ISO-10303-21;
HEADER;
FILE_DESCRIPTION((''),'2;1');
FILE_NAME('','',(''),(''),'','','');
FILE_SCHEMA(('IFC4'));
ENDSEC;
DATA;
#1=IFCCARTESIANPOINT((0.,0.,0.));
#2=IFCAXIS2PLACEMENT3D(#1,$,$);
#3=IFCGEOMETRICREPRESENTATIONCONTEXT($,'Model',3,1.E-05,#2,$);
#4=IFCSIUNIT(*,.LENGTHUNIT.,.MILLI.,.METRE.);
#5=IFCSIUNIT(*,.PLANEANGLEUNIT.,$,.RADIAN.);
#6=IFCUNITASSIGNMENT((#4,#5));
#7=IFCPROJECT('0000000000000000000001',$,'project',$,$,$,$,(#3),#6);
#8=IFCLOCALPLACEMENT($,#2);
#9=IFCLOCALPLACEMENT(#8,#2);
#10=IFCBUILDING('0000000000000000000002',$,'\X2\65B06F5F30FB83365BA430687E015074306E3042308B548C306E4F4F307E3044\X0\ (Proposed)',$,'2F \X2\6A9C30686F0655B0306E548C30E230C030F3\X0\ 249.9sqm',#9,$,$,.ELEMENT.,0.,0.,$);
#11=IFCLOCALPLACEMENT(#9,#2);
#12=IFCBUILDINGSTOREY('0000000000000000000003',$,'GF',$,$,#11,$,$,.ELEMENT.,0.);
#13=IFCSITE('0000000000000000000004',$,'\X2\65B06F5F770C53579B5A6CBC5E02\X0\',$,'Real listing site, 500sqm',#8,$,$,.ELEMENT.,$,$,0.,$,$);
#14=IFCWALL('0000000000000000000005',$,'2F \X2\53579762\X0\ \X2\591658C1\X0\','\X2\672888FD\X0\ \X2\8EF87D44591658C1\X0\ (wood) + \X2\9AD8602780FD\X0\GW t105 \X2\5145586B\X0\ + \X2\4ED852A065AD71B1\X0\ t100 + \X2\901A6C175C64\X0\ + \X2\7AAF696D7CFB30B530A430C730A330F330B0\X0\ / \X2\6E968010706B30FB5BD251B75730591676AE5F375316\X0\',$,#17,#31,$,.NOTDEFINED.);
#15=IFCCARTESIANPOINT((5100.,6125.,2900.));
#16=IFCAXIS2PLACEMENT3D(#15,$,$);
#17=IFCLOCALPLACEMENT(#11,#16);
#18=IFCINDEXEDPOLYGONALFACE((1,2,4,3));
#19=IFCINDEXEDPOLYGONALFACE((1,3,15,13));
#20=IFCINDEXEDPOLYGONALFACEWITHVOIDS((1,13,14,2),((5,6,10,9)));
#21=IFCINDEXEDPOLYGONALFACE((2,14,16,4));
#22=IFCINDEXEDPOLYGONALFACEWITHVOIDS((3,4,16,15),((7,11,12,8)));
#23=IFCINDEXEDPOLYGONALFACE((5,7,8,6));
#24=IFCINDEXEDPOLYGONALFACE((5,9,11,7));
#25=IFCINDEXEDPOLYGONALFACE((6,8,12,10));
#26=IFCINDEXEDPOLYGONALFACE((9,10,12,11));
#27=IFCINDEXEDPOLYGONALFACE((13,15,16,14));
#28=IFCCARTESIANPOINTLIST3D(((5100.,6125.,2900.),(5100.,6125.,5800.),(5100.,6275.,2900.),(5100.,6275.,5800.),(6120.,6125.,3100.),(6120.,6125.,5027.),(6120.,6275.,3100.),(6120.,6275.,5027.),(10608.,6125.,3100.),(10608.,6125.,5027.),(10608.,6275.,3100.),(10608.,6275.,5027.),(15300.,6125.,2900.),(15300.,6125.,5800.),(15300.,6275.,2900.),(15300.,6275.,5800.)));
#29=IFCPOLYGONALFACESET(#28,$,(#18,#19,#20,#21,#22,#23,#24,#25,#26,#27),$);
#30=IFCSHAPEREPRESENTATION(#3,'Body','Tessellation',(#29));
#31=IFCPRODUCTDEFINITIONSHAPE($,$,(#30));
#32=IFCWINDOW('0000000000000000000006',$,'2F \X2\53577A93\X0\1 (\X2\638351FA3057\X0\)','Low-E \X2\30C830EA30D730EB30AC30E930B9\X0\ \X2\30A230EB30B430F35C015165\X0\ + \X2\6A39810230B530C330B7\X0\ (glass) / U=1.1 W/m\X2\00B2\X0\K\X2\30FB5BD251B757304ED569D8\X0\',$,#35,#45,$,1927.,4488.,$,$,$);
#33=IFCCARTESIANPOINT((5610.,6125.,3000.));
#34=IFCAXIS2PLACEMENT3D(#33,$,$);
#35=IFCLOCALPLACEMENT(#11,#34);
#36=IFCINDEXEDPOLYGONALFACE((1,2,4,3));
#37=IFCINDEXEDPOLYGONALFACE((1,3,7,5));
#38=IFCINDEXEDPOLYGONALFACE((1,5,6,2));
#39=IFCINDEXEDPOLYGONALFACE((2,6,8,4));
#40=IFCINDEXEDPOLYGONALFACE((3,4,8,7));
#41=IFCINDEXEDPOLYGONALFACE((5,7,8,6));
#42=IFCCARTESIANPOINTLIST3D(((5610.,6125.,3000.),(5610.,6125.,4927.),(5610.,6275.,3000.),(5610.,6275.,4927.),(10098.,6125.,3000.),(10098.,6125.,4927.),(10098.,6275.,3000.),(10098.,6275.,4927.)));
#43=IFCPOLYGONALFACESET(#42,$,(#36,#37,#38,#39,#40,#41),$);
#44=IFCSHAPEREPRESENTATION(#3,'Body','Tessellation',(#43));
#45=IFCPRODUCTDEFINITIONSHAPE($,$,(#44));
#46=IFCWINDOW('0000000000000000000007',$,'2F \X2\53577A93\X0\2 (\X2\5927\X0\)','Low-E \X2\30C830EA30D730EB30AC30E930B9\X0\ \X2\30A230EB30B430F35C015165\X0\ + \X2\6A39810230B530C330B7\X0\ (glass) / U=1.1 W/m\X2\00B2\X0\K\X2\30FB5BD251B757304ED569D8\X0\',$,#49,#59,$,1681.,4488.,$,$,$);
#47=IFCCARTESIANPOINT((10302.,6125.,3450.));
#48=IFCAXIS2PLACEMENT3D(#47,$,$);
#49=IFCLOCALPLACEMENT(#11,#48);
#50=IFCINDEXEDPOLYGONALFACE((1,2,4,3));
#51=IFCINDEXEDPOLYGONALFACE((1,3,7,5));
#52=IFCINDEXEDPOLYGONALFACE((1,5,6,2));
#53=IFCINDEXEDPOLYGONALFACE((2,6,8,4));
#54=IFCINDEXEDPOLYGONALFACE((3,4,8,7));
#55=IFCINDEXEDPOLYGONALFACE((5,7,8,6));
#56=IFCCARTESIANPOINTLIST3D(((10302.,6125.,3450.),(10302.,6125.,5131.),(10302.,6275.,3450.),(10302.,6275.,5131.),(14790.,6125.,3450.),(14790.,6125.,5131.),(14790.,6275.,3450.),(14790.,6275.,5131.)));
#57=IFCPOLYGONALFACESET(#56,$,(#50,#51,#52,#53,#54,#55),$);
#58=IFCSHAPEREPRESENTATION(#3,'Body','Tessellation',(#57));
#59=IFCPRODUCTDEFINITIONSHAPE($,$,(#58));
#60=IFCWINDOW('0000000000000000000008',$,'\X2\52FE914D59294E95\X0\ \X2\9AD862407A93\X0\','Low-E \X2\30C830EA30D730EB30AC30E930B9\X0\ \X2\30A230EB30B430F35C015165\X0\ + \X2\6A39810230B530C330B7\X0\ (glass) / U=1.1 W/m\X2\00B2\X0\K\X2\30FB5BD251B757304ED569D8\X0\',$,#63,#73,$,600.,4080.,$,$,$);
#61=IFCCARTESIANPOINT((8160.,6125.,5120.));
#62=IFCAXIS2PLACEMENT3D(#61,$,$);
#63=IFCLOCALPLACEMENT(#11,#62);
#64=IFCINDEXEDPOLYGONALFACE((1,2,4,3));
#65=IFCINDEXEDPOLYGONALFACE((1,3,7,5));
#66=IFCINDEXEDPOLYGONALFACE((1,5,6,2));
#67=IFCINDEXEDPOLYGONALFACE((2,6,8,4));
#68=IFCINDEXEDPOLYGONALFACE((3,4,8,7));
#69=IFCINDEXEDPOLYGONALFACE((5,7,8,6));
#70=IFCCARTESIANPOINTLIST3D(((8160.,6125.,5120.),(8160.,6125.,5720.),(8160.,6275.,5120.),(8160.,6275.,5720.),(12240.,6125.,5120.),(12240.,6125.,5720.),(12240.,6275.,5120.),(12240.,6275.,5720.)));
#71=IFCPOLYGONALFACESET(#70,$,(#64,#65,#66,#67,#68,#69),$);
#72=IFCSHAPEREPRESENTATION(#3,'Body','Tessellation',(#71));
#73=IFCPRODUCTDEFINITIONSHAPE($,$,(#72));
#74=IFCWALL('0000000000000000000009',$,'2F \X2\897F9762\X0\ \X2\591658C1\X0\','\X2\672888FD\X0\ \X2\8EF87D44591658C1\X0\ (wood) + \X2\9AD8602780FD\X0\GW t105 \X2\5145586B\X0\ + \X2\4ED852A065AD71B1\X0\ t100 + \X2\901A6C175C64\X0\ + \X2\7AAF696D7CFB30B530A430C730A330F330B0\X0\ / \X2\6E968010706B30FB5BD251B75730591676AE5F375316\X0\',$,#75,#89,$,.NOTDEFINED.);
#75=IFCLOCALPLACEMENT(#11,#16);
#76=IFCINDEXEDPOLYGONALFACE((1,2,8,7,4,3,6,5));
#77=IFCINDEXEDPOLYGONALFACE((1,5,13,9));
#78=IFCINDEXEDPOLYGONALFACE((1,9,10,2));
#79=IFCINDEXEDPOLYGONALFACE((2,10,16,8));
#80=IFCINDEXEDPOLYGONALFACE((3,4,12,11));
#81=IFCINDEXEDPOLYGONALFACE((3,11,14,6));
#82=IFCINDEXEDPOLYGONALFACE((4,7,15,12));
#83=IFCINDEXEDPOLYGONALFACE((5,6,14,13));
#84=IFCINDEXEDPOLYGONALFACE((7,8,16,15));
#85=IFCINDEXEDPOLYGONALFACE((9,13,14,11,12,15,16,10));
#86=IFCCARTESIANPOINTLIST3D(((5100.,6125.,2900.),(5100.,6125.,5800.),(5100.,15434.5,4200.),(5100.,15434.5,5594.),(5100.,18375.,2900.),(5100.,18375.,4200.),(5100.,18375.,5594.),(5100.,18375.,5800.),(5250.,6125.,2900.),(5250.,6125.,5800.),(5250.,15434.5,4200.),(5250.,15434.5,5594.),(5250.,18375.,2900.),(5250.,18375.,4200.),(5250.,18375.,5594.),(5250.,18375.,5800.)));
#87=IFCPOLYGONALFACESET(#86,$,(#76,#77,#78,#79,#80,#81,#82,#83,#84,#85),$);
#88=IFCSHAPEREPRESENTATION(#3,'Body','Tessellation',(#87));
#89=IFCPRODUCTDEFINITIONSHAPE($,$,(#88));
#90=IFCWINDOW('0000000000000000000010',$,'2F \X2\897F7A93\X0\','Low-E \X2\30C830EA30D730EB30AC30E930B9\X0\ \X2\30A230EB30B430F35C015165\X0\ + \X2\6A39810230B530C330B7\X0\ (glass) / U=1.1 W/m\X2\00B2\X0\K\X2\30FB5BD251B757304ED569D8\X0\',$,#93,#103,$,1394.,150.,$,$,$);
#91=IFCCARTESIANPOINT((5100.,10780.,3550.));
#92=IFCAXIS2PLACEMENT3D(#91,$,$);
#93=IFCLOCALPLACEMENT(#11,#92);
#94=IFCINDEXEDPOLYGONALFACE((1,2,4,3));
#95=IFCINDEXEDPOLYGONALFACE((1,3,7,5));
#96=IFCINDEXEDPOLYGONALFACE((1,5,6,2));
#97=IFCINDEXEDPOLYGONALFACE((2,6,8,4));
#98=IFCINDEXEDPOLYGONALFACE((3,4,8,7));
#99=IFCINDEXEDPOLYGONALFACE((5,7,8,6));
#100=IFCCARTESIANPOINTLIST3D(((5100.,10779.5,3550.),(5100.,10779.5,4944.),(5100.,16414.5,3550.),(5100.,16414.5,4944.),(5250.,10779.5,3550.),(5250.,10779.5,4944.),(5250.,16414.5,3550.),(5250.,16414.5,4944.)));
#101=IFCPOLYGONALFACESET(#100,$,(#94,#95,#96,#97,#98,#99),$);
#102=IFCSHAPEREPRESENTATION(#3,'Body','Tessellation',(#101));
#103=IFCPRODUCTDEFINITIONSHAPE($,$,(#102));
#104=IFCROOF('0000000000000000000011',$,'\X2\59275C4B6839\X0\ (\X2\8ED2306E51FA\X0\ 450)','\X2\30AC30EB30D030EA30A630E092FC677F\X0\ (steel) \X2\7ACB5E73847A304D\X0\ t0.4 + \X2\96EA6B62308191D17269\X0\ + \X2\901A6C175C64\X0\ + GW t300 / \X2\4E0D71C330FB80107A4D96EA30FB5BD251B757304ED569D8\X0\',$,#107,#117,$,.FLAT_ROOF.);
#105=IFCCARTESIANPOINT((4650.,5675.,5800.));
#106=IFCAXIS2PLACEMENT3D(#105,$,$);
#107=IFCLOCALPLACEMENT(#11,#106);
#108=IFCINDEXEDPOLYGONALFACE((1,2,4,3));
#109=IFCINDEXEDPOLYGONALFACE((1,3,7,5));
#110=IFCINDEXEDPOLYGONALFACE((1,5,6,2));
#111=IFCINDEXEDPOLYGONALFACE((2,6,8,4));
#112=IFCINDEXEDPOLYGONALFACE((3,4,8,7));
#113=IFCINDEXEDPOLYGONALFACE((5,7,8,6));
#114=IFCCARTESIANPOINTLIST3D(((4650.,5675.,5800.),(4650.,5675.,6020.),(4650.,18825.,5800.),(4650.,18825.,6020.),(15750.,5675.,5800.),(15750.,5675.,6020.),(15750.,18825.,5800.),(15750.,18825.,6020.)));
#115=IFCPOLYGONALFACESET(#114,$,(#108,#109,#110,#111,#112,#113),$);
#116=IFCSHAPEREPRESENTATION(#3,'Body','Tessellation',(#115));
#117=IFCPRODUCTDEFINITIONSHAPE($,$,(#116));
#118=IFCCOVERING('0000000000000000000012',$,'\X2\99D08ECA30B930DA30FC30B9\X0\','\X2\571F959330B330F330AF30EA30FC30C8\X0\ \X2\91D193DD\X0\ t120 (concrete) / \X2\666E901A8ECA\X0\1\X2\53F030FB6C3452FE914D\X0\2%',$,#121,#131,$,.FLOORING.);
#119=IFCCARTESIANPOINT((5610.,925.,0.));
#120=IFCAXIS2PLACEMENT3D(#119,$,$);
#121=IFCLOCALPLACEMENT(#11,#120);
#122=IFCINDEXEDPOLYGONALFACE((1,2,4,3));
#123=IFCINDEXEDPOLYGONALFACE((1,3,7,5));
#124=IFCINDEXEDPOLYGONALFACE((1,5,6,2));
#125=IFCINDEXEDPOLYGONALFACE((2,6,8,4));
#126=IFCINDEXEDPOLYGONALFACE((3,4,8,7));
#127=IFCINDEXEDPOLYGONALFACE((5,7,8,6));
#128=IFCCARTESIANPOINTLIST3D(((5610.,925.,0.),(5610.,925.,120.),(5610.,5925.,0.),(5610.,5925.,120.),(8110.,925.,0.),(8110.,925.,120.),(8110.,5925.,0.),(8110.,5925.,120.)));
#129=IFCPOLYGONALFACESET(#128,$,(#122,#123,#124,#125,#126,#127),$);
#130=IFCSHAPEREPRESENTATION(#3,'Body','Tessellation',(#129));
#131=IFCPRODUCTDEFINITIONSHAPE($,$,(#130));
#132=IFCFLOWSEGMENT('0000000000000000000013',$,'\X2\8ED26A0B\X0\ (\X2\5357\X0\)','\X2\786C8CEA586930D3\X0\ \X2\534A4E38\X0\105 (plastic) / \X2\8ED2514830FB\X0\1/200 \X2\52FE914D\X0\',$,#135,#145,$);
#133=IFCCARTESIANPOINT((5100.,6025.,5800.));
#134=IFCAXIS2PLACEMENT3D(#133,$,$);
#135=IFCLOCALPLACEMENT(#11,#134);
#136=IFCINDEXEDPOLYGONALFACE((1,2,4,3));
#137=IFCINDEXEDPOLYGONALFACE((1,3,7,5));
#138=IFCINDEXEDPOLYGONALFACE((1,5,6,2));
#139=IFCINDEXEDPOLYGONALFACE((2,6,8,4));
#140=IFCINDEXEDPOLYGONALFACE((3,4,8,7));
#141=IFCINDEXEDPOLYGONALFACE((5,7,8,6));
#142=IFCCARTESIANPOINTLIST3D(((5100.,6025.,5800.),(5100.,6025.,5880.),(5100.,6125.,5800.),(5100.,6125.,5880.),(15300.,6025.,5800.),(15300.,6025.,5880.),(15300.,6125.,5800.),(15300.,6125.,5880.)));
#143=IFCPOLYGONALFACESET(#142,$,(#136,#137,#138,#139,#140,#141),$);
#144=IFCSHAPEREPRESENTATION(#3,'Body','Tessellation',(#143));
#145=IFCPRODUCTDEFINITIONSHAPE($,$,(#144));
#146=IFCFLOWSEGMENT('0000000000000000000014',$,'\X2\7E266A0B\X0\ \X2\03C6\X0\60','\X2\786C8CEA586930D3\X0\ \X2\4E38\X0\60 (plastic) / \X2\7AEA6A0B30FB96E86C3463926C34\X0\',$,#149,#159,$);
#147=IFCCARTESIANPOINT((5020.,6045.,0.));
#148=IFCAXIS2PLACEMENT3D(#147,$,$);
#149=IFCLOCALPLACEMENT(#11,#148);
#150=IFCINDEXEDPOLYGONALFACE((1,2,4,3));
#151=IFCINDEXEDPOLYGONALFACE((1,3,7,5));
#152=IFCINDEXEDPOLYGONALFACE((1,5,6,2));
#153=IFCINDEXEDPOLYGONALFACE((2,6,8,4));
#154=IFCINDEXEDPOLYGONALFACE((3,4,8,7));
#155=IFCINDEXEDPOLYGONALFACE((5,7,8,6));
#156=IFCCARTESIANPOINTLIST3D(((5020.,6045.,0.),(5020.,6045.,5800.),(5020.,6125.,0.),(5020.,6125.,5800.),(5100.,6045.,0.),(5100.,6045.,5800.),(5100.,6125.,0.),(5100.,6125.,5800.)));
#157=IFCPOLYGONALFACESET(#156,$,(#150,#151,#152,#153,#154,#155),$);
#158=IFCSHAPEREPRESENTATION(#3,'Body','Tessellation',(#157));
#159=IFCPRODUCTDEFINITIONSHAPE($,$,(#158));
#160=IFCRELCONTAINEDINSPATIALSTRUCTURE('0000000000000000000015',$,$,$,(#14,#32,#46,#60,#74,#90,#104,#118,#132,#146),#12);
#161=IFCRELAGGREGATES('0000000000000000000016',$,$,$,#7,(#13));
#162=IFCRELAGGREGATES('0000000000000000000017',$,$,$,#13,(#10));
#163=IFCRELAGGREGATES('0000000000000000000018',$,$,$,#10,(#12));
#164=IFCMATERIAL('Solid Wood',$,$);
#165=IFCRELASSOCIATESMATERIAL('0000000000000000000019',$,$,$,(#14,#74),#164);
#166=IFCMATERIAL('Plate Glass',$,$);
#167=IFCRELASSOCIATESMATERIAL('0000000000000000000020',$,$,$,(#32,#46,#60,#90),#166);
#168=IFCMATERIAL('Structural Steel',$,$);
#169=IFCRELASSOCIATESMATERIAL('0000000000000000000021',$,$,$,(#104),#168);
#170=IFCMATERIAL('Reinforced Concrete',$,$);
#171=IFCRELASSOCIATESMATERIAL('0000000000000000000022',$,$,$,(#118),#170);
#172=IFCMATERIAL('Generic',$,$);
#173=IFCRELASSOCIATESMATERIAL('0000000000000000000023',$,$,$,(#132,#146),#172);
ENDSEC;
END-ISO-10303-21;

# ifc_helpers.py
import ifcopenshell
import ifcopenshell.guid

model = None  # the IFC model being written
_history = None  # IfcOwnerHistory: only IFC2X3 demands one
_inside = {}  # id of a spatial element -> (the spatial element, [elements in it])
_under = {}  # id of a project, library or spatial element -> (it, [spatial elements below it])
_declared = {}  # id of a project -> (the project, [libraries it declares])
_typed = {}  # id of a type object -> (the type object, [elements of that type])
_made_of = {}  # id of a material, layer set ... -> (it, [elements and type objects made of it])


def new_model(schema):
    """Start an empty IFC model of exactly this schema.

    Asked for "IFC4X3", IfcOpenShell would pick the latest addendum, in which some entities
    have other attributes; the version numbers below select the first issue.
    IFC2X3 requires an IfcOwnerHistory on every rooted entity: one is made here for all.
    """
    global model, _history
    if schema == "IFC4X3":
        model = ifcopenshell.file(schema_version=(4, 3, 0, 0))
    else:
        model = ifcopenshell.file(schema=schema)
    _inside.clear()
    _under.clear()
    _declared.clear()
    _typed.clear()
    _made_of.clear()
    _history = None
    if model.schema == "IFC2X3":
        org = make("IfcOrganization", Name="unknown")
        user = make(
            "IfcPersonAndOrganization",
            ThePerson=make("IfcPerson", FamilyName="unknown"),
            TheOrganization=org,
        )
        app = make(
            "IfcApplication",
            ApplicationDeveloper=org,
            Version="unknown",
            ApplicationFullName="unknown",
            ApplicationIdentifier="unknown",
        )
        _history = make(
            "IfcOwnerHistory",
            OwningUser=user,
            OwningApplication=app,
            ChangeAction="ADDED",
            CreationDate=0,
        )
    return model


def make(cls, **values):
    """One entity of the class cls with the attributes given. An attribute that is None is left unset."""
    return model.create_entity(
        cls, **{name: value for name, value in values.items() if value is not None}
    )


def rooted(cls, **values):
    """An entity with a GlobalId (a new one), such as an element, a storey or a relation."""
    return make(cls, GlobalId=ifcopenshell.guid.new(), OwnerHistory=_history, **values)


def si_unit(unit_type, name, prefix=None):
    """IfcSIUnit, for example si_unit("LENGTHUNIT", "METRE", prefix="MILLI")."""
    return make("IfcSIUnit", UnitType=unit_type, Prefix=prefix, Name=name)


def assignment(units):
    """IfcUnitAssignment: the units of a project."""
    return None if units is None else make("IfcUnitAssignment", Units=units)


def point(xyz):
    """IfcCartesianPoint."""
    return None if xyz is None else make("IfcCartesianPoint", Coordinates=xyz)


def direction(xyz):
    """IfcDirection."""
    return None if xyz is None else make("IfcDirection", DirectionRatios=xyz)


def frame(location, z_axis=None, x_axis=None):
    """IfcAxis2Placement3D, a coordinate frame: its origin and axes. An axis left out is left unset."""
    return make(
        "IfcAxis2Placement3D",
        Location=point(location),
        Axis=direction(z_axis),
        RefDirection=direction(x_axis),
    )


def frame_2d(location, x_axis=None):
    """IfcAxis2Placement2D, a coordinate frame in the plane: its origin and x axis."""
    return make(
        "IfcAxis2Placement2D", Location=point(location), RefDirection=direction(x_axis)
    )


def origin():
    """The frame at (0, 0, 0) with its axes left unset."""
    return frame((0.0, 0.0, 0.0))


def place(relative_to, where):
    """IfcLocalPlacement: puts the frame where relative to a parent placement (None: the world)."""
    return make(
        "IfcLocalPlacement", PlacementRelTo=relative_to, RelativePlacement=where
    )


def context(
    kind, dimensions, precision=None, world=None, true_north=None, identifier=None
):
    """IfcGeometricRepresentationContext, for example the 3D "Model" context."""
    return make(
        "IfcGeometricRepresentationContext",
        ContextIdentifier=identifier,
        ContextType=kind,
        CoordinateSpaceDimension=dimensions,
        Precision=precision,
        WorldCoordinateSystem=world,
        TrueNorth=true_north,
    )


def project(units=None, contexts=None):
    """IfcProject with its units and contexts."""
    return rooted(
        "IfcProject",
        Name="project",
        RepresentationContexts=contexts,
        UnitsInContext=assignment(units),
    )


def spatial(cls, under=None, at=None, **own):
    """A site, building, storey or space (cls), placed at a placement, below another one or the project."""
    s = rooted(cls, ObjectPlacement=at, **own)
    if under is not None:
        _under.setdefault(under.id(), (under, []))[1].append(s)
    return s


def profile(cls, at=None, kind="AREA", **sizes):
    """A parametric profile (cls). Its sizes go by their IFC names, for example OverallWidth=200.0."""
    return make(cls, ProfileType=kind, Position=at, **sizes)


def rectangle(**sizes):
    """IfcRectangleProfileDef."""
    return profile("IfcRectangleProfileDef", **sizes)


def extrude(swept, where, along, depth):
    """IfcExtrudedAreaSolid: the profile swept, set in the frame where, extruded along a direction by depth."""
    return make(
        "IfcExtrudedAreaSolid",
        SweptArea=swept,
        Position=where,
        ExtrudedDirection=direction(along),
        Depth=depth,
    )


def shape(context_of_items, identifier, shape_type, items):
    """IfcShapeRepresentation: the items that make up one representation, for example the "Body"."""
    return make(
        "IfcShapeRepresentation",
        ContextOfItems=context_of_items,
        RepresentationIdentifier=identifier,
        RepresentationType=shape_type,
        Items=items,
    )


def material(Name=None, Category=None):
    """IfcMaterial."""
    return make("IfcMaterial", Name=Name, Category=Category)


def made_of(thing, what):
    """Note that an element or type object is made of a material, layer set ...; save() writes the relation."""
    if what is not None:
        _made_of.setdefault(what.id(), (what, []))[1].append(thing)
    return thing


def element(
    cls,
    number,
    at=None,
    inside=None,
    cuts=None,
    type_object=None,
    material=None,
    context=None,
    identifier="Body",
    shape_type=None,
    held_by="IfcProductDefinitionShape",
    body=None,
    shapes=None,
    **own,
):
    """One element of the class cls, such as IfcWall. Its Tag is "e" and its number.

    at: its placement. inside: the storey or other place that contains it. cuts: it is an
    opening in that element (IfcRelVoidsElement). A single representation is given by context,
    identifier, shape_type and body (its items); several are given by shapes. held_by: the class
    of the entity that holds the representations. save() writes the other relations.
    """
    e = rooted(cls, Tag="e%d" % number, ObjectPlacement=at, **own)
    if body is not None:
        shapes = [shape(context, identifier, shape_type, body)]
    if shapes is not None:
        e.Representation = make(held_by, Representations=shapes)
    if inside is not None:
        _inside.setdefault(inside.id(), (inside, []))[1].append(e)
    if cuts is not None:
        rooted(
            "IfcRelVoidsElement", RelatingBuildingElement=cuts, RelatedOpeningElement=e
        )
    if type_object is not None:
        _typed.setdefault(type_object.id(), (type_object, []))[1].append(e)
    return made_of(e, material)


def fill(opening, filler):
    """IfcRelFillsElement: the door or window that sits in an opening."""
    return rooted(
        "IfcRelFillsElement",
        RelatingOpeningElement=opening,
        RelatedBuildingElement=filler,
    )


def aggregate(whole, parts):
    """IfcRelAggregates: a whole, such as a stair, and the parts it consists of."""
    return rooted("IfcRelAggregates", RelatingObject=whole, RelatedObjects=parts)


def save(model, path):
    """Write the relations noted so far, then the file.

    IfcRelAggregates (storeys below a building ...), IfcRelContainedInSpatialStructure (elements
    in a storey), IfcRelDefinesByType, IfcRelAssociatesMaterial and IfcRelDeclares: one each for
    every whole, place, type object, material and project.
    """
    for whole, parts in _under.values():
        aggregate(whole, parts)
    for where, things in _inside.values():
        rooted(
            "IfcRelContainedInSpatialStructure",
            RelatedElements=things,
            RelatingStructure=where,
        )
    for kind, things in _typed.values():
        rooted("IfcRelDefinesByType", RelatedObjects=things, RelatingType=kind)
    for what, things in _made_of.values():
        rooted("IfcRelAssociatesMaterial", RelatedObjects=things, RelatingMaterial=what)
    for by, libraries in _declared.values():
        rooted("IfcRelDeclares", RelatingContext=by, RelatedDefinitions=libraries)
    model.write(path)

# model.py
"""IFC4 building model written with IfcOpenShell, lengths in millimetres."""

from ifc_helpers import new_model, si_unit, frame, frame_2d, origin, place, context, project, spatial, rectangle, extrude, material, element, fill, save


model = new_model("IFC4")

# Units and contexts
model_context = context("Model", 3, precision=1e-05, world=origin())
ifc_project = project(units=[si_unit("LENGTHUNIT", "METRE", prefix="MILLI"), si_unit("PLANEANGLEUNIT", "RADIAN")], contexts=[model_context])

# Site, building, storey
site_placement = place(None, origin())
site = spatial("IfcSite", under=ifc_project, at=site_placement, Name="新潟県南魚沼市", ObjectType="Real listing site, 500sqm", CompositionType="ELEMENT", RefElevation=0.0)
building_placement = place(site_placement, origin())
building = spatial("IfcBuilding", under=site, at=building_placement, Name="新潟・茶室と縁側のある和の住まい (Proposed)", ObjectType="2F 檜と漆喰の和モダン 249.9sqm", CompositionType="ELEMENT", ElevationOfRefHeight=0.0, ElevationOfTerrain=0.0)
storey_placement = place(building_placement, origin())
storey = spatial("IfcBuildingStorey", under=building, at=storey_placement, Name="GF", CompositionType="ELEMENT", Elevation=0.0)

# Shared definitions
ifc_material_1 = material(Name="Solid Wood")

# Shared definitions
ifc_material_2 = material(Name="Reinforced Concrete")

# Shared definitions
ifc_material_3 = material(Name="Plate Glass")

# Wall, openings, windows
wall_1_placement = place(storey_placement, frame((5100.0, 6125.0, 2900.0)))
wall_1 = element("IfcWall", 1, at=wall_1_placement, inside=storey, material=ifc_material_1, Name="2F 南面 外壁", Description="木製 軸組外壁 (wood) + 高性能GW t105 充填 + 付加断熱 t100 + 通気層 + 窯業系サイディング / 準耐火・寒冷地外皮強化", PredefinedType="NOTDEFINED", context=model_context, shape_type="SweptSolid", body=[
    extrude(rectangle(XDim=10200.0, YDim=150.0, at=frame_2d((5100.0, 75.0))), frame((5100.0, 6125.0, 2900.0)), (0.0, 0.0, 1.0), 2900.0),
])
opening_1_placement = place(storey_placement, frame((5610.0, 6125.0, 3000.0)))
opening_1 = element("IfcOpeningElement", 2, at=opening_1_placement, cuts=wall_1, PredefinedType="NOTDEFINED", context=model_context, shape_type="SweptSolid", body=[
    extrude(rectangle(XDim=4488.0, YDim=150.0, at=frame_2d((2244.0, 75.0))), frame((5610.0, 6125.0, 3000.0)), (0.0, 0.0, 1.0), 1927.0),
])
opening_2_placement = place(storey_placement, frame((10302.0, 6125.0, 3450.0)))
opening_2 = element("IfcOpeningElement", 3, at=opening_2_placement, cuts=wall_1, PredefinedType="NOTDEFINED", context=model_context, shape_type="SweptSolid", body=[
    extrude(rectangle(XDim=4488.0, YDim=150.0, at=frame_2d((2244.0, 75.0))), frame((10302.0, 6125.0, 3450.0)), (0.0, 0.0, 1.0), 1681.0),
])
opening_3_placement = place(storey_placement, frame((8160.0, 6125.0, 5120.0)))
opening_3 = element("IfcOpeningElement", 4, at=opening_3_placement, cuts=wall_1, PredefinedType="NOTDEFINED", context=model_context, shape_type="SweptSolid", body=[
    extrude(rectangle(XDim=4080.0, YDim=150.0, at=frame_2d((2040.0, 75.0))), frame((8160.0, 6125.0, 5120.0)), (0.0, 0.0, 1.0), 600.0),
])
window_1_placement = place(storey_placement, frame((5610.0, 6125.0, 3000.0)))
window_1 = element("IfcWindow", 5, at=window_1_placement, inside=storey, material=ifc_material_3, Name="2F 南窓1 (掃出し)", Description="Low-E トリプルガラス アルゴン封入 + 樹脂サッシ (glass) / U=1.1 W/m²K・寒冷地仕様", OverallHeight=1927.0, OverallWidth=4488.0, context=model_context, shape_type="SweptSolid", body=[
    extrude(rectangle(XDim=4488.0, YDim=150.0, at=frame_2d((2244.0, 75.0))), frame((5610.0, 6125.0, 3000.0)), (0.0, 0.0, 1.0), 1927.0),
])
fill(opening_1, window_1)
window_2_placement = place(storey_placement, frame((10302.0, 6125.0, 3450.0)))
window_2 = element("IfcWindow", 6, at=window_2_placement, inside=storey, material=ifc_material_3, Name="2F 南窓2 (大)", Description="Low-E トリプルガラス アルゴン封入 + 樹脂サッシ (glass) / U=1.1 W/m²K・寒冷地仕様", OverallHeight=1681.0, OverallWidth=4488.0, context=model_context, shape_type="SweptSolid", body=[
    extrude(rectangle(XDim=4488.0, YDim=150.0, at=frame_2d((2244.0, 75.0))), frame((10302.0, 6125.0, 3450.0)), (0.0, 0.0, 1.0), 1681.0),
])
fill(opening_2, window_2)
window_3_placement = place(storey_placement, frame((8160.0, 6125.0, 5120.0)))
window_3 = element("IfcWindow", 7, at=window_3_placement, inside=storey, material=ifc_material_3, Name="勾配天井 高所窓", Description="Low-E トリプルガラス アルゴン封入 + 樹脂サッシ (glass) / U=1.1 W/m²K・寒冷地仕様", OverallHeight=600.0, OverallWidth=4080.0, context=model_context, shape_type="SweptSolid", body=[
    extrude(rectangle(XDim=4080.0, YDim=150.0, at=frame_2d((2040.0, 75.0))), frame((8160.0, 6125.0, 5120.0)), (0.0, 0.0, 1.0), 600.0),
])
fill(opening_3, window_3)

# Wall, opening, window
wall_2_placement = place(storey_placement, frame((5100.0, 6125.0, 2900.0)))
wall_2 = element("IfcWall", 8, at=wall_2_placement, inside=storey, material=ifc_material_1, Name="2F 西面 外壁", Description="木製 軸組外壁 (wood) + 高性能GW t105 充填 + 付加断熱 t100 + 通気層 + 窯業系サイディング / 準耐火・寒冷地外皮強化", PredefinedType="NOTDEFINED", context=model_context, shape_type="SweptSolid", body=[
    extrude(rectangle(XDim=150.0, YDim=12250.0, at=frame_2d((75.0, 6125.0))), frame((5100.0, 6125.0, 2900.0)), (0.0, 0.0, 1.0), 2900.0),
])
opening_4_placement = place(storey_placement, frame((5100.0, 10780.0, 3550.0)))
opening_4 = element("IfcOpeningElement", 9, at=opening_4_placement, cuts=wall_2, PredefinedType="NOTDEFINED", context=model_context, shape_type="SweptSolid", body=[
    extrude(rectangle(XDim=150.0, YDim=5635.0, at=frame_2d((75.0, 2817.0))), frame((5100.0, 10780.0, 3550.0)), (0.0, 0.0, 1.0), 1394.0),
])
window_4_placement = place(storey_placement, frame((5100.0, 10780.0, 3550.0)))
window_4 = element("IfcWindow", 10, at=window_4_placement, inside=storey, material=ifc_material_3, Name="2F 西窓", Description="Low-E トリプルガラス アルゴン封入 + 樹脂サッシ (glass) / U=1.1 W/m²K・寒冷地仕様", OverallHeight=1394.0, OverallWidth=150.0, context=model_context, shape_type="SweptSolid", body=[
    extrude(rectangle(XDim=150.0, YDim=5635.0, at=frame_2d((75.0, 2817.0))), frame((5100.0, 10780.0, 3550.0)), (0.0, 0.0, 1.0), 1394.0),
])
fill(opening_4, window_4)

# Roof
ifc_material_4 = material(Name="Structural Steel")
roof_placement = place(storey_placement, frame((4650.0, 5675.0, 5800.0)))
element("IfcRoof", 11, at=roof_placement, inside=storey, material=ifc_material_4, Name="大屋根 (軒の出 450)", Description="ガルバリウム鋼板 (steel) 立平葺き t0.4 + 雪止め金物 + 通気層 + GW t300 / 不燃・耐積雪・寒冷地仕様", PredefinedType="FLAT_ROOF", context=model_context, shape_type="SweptSolid", body=[
    extrude(rectangle(XDim=11100.0, YDim=13150.0, at=frame_2d((5550.0, 6575.0))), frame((4650.0, 5675.0, 5800.0)), (0.0, 0.0, 1.0), 220.0),
])

# Covering
covering_placement = place(storey_placement, frame((5610.0, 925.0, 0.0)))
element("IfcCovering", 12, at=covering_placement, inside=storey, material=ifc_material_2, Name="駐車スペース", Description="土間コンクリート 金鏝 t120 (concrete) / 普通車1台・水勾配2%", PredefinedType="FLOORING", context=model_context, shape_type="SweptSolid", body=[
    extrude(rectangle(XDim=2500.0, YDim=5000.0, at=frame_2d((1250.0, 2500.0))), frame((5610.0, 925.0, 0.0)), (0.0, 0.0, 1.0), 120.0),
])

# Flow segments
ifc_material_5 = material(Name="Generic")
flow_segment_1_placement = place(storey_placement, frame((5100.0, 6025.0, 5800.0)))
element("IfcFlowSegment", 13, at=flow_segment_1_placement, inside=storey, material=ifc_material_5, Name="軒樋 (南)", Description="硬質塩ビ 半丸105 (plastic) / 軒先・1/200 勾配", context=model_context, shape_type="SweptSolid", body=[
    extrude(rectangle(XDim=10200.0, YDim=100.0, at=frame_2d((5100.0, 50.0))), frame((5100.0, 6025.0, 5800.0)), (0.0, 0.0, 1.0), 80.0),
])
flow_segment_2_placement = place(storey_placement, frame((5020.0, 6045.0, 0.0)))
element("IfcFlowSegment", 14, at=flow_segment_2_placement, inside=storey, material=ifc_material_5, Name="縦樋 φ60", Description="硬質塩ビ 丸60 (plastic) / 竪樋・雨水排水", context=model_context, shape_type="SweptSolid", body=[
    extrude(rectangle(XDim=80.0, YDim=80.0, at=frame_2d((40.0, 40.0))), frame((5020.0, 6045.0, 0.0)), (0.0, 0.0, 1.0), 5800.0),
])

save(model, "model.ifc")
